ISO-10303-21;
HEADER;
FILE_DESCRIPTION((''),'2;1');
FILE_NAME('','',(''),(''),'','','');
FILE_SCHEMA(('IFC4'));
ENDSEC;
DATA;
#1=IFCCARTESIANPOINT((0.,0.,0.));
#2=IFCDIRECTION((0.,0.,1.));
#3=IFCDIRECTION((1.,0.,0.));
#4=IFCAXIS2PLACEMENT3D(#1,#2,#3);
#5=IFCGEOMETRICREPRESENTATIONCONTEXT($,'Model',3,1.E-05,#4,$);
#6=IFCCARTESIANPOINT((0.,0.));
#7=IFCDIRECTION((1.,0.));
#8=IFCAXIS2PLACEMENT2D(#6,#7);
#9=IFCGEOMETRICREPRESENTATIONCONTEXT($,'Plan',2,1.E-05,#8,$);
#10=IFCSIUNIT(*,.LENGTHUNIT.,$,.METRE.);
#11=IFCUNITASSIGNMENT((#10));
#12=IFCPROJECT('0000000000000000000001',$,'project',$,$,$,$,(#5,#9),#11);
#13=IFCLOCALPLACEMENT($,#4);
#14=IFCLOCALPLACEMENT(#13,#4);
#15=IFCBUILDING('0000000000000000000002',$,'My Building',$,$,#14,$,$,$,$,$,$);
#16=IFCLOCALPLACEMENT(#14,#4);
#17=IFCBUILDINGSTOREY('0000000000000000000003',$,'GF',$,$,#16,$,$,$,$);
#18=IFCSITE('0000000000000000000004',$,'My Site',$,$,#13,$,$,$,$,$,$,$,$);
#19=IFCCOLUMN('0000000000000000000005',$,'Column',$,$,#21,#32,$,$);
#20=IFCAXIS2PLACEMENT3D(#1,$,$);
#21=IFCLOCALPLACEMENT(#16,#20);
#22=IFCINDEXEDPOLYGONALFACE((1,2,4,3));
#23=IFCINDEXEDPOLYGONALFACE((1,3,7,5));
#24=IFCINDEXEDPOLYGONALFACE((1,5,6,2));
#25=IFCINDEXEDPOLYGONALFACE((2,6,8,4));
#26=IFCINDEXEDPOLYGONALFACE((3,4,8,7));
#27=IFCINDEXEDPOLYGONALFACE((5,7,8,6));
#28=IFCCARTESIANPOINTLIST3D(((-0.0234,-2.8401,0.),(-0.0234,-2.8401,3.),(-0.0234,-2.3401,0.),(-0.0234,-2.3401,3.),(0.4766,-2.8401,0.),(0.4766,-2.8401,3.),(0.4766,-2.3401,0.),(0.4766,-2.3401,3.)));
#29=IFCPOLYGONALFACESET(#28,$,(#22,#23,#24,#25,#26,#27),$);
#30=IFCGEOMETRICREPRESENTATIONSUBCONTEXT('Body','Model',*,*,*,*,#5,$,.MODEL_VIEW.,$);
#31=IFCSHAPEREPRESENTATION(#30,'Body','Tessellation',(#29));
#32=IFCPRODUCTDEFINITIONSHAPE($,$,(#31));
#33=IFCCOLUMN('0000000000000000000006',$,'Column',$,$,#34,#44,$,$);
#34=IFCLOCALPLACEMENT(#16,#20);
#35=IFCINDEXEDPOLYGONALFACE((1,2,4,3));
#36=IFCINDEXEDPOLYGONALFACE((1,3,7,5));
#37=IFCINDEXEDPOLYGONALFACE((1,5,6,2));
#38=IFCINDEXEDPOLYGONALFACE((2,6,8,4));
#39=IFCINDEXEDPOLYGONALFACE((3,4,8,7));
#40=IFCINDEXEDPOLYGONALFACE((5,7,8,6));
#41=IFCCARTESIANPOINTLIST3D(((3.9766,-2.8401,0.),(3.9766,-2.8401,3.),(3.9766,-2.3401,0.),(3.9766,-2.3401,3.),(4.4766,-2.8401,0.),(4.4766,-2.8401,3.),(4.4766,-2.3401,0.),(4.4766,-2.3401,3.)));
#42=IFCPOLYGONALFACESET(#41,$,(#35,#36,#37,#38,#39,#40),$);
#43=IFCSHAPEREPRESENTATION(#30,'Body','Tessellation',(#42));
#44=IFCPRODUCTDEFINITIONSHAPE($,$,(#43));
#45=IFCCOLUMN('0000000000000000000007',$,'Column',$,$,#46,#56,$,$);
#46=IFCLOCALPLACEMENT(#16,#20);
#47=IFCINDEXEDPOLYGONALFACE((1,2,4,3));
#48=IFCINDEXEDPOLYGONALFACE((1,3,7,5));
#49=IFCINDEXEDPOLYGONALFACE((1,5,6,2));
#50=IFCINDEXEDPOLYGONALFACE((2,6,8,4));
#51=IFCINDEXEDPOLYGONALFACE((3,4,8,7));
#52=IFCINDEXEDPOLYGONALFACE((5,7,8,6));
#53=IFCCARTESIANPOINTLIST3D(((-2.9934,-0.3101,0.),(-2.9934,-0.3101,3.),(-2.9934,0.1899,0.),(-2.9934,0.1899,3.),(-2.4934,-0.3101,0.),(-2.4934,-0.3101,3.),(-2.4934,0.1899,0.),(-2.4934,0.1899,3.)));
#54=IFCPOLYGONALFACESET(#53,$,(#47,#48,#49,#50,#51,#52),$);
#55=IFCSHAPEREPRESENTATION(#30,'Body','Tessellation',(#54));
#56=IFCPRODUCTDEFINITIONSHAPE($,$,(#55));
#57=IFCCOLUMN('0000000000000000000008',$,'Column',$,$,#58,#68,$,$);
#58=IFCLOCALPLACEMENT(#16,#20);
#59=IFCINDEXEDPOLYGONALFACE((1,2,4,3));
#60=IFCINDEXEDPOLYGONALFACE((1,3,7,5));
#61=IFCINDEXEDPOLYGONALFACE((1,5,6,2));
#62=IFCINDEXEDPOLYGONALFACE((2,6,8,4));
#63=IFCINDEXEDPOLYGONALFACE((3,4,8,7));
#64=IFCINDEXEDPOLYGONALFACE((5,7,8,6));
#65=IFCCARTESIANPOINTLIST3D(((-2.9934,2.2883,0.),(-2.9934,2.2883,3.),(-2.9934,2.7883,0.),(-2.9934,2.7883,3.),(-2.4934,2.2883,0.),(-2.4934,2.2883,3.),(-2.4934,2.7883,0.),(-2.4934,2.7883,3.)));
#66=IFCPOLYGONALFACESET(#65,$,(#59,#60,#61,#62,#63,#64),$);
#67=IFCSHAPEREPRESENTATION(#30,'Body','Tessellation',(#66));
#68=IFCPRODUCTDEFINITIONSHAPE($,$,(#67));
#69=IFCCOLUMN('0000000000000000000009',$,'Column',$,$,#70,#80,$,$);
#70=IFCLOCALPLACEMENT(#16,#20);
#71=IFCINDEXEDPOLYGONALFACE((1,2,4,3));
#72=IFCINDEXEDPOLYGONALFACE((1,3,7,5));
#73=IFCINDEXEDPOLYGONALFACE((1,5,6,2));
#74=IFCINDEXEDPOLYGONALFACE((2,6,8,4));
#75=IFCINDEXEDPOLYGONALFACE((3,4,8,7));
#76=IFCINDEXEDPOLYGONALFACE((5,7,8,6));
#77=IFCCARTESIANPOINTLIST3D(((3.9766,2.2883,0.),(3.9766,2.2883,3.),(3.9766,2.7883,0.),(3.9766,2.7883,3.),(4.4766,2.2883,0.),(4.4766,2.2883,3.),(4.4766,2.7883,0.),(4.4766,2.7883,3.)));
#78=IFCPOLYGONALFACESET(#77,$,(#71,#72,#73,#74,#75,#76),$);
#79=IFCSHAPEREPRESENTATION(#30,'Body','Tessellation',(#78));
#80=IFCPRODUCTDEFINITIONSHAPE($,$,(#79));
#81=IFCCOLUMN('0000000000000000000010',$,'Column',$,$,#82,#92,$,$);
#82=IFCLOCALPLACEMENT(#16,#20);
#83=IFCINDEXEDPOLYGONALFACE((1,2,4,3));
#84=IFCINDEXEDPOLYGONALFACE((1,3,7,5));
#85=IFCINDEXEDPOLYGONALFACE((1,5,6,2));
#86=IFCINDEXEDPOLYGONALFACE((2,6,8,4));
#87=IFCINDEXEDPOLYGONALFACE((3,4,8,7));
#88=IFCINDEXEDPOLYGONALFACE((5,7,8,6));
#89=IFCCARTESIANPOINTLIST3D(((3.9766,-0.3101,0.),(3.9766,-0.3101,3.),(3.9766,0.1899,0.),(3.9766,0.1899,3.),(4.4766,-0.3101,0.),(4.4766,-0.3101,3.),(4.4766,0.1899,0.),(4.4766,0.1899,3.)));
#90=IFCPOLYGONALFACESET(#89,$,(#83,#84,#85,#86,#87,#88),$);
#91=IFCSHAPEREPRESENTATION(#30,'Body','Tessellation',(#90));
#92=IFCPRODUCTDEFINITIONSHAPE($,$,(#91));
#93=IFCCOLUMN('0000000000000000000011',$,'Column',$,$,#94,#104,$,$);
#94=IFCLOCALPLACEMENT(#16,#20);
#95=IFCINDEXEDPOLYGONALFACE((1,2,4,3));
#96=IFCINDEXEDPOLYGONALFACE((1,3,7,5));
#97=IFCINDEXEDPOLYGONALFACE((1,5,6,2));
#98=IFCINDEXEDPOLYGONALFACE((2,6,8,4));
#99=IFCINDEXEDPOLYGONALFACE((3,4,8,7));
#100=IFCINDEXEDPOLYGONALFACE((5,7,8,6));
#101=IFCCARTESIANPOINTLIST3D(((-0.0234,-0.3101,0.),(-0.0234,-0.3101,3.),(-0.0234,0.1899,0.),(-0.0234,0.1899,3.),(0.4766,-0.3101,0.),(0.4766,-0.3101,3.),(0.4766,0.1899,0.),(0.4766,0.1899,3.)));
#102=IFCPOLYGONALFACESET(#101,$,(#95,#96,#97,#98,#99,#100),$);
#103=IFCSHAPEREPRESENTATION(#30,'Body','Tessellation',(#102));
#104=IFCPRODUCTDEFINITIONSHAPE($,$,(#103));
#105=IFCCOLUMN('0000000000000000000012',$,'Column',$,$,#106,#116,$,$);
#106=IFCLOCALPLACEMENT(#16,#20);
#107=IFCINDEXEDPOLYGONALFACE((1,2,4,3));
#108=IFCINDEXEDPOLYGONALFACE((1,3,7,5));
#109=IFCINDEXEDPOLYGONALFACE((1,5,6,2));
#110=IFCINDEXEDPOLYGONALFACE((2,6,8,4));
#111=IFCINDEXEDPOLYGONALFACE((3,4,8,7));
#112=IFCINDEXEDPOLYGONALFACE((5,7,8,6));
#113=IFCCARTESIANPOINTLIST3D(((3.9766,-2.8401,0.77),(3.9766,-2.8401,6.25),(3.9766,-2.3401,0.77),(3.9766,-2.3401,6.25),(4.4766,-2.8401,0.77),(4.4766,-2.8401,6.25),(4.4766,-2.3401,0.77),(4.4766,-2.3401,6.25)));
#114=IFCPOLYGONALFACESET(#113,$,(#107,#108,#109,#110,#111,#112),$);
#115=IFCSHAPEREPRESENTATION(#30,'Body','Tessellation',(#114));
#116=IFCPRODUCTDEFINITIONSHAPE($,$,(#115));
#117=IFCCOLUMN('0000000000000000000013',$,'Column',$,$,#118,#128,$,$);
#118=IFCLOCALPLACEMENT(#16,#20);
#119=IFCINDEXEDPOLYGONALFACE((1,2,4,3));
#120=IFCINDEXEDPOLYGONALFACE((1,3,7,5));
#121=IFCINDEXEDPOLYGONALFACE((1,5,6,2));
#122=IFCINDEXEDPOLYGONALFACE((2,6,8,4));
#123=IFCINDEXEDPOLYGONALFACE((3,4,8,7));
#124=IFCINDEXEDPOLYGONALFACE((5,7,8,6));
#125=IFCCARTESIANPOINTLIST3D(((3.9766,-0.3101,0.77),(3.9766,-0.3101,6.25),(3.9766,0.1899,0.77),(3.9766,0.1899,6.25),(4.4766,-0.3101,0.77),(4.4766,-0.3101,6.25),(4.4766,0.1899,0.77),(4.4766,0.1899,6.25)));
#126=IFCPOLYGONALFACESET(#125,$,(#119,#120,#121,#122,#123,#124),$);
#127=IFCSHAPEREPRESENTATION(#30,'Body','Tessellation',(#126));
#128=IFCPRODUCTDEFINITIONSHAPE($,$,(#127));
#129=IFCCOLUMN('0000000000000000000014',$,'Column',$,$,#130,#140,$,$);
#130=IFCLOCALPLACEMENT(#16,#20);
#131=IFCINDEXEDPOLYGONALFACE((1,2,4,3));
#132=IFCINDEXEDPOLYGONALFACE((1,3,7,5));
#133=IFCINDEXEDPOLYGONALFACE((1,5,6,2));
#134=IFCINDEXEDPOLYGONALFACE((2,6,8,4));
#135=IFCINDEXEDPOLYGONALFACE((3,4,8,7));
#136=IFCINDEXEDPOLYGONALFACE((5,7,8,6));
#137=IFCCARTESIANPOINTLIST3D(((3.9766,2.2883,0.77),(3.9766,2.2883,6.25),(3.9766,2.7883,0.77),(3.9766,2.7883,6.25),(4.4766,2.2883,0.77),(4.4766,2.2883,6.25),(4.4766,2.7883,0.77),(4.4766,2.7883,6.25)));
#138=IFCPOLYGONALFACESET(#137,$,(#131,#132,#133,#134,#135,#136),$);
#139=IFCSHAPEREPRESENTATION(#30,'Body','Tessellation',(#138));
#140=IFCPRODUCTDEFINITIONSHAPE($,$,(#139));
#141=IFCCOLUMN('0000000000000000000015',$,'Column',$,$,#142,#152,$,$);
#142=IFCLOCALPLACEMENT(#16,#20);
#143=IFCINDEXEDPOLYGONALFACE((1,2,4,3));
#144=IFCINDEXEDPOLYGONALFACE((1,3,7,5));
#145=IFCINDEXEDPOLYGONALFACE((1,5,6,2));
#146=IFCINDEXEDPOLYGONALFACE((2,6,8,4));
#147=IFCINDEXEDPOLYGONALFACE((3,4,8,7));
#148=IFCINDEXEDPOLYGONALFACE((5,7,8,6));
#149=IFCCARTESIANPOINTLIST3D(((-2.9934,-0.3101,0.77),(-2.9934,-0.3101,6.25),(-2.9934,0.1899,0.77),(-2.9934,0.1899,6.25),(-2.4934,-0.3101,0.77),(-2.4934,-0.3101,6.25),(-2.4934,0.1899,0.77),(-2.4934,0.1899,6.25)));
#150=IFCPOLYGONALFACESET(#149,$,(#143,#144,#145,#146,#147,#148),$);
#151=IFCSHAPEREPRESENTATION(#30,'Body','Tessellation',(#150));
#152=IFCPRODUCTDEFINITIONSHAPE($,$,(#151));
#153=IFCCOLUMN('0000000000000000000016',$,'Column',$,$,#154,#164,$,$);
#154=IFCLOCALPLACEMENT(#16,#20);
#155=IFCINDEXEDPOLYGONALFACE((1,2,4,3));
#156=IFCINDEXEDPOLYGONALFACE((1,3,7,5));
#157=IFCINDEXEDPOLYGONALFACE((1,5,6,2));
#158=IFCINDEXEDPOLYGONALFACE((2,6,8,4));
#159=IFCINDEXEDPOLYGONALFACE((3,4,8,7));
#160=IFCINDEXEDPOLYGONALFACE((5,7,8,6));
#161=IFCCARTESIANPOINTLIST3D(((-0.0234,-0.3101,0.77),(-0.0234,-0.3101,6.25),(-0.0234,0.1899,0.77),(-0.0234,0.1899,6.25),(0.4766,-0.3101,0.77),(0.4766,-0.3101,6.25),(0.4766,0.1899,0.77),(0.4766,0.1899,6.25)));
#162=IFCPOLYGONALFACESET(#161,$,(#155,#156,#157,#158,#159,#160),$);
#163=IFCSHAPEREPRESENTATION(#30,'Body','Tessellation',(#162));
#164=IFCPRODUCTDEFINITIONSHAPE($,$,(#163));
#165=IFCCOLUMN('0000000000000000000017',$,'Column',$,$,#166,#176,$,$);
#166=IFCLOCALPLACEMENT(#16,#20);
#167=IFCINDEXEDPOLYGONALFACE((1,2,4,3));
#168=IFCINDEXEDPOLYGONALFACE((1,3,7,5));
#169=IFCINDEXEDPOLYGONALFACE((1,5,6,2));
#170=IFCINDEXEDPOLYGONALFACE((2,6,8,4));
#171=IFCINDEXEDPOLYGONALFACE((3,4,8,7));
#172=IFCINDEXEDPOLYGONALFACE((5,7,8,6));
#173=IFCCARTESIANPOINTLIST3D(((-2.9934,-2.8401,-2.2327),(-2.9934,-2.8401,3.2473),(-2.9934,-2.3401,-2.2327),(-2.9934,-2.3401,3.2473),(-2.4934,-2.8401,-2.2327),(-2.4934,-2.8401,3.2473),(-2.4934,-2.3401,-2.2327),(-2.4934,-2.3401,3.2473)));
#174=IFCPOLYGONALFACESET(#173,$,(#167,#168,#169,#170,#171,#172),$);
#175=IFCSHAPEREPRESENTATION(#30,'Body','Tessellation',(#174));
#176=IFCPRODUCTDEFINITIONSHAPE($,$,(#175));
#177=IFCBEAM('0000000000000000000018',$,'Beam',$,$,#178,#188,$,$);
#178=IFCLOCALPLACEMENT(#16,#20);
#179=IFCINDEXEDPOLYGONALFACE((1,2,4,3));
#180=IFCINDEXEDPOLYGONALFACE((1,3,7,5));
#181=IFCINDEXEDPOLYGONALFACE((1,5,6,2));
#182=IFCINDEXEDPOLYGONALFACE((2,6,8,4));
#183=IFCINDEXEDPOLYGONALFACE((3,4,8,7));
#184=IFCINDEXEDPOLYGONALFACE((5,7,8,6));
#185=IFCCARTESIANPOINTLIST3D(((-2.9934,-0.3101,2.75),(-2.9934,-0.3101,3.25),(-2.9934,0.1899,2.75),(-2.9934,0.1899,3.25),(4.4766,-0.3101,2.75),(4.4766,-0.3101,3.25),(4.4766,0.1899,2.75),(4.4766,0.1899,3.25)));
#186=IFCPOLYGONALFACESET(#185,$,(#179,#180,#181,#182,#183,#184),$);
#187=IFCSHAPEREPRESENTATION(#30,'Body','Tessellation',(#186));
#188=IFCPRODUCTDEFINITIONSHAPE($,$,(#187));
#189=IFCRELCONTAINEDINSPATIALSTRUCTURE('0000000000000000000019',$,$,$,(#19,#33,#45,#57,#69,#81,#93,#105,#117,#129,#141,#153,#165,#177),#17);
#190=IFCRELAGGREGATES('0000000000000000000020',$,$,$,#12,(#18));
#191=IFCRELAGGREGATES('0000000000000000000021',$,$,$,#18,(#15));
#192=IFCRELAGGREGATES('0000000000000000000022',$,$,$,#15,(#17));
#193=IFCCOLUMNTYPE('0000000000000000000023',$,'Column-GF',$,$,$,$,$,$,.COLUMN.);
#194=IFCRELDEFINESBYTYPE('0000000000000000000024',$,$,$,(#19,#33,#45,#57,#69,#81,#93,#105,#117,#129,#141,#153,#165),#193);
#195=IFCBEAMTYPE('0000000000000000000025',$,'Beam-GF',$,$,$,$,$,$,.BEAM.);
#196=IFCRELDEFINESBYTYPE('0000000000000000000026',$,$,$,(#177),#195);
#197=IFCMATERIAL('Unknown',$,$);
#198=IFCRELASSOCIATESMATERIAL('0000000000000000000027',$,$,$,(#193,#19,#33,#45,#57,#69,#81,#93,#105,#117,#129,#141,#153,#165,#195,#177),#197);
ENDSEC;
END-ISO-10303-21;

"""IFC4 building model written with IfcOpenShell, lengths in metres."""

from ifc_helpers import new_model, si_unit, frame, origin_with_axes, origin_2d_with_axis, place, context, subcontext, project, spatial, rectangle, extrude, material, material_profile, profile_set, profile_usage, type_object, element, save


model = new_model("IFC4")

# Units and contexts
model_context = context("Model", 3, precision=1e-05, world=origin_with_axes())
plan_context = context("Plan", 2, precision=1e-05, world=origin_2d_with_axis())
body_context_1 = subcontext(model_context, "Body", "Model", "MODEL_VIEW")
ifc_project = project(units=[si_unit("LENGTHUNIT", "METRE")], contexts=[model_context, plan_context])

# Site, building, storey
site_placement = place(None, origin_with_axes())
site = spatial("IfcSite", under=ifc_project, at=site_placement, Name="My Site")
building_placement = place(site_placement, origin_with_axes())
building = spatial("IfcBuilding", under=site, at=building_placement, Name="My Building")
storey_placement = place(building_placement, origin_with_axes())
storey = spatial("IfcBuildingStorey", under=building, at=storey_placement, Name="GF")

# Columns
ifc_material = material(Name="Unknown")
ifc_material_profile_1 = material_profile(ifc_material, rectangle(XDim=0.5, YDim=0.5))
ifc_profile_set_1 = profile_set([ifc_material_profile_1])
ifc_profile_usage_1 = profile_usage(ifc_profile_set_1, cardinal=5)
column_type = type_object("IfcColumnType", Name="Column-GF", PredefinedType="COLUMN", material=ifc_profile_set_1)
column_1_placement = place(storey_placement, frame((0.2266, -2.5901, 0.0), z_axis=(0.0, 0.0, 1.0), x_axis=(1.0, 0.0, 0.0)))
element("IfcColumn", 1, at=column_1_placement, inside=storey, type_object=column_type, material=ifc_profile_usage_1, Name="Column", context=body_context_1, shape_type="SweptSolid", body=[
    extrude(rectangle(XDim=0.5, YDim=0.5), origin_with_axes(), (0.0, 0.0, 1.0), 3.0),
])
ifc_profile_usage_2 = profile_usage(ifc_profile_set_1, cardinal=5)
column_2_placement = place(storey_placement, frame((4.2266, -2.5901, 0.0), z_axis=(0.0, 0.0, 1.0), x_axis=(1.0, 0.0, 0.0)))
element("IfcColumn", 2, at=column_2_placement, inside=storey, type_object=column_type, material=ifc_profile_usage_2, Name="Column", context=body_context_1, shape_type="SweptSolid", body=[
    extrude(rectangle(XDim=0.5, YDim=0.5), origin_with_axes(), (0.0, 0.0, 1.0), 3.0),
])
ifc_profile_usage_3 = profile_usage(ifc_profile_set_1, cardinal=5)
column_3_placement = place(storey_placement, frame((-2.7434, -0.0601, 0.0), z_axis=(0.0, 0.0, 1.0), x_axis=(1.0, 0.0, 0.0)))
element("IfcColumn", 3, at=column_3_placement, inside=storey, type_object=column_type, material=ifc_profile_usage_3, Name="Column", context=body_context_1, shape_type="SweptSolid", body=[
    extrude(rectangle(XDim=0.5, YDim=0.5), origin_with_axes(), (0.0, 0.0, 1.0), 3.0),
])
ifc_profile_usage_4 = profile_usage(ifc_profile_set_1, cardinal=5)
column_4_placement = place(storey_placement, frame((-2.7434, 2.5383, 0.0), z_axis=(0.0, 0.0, 1.0), x_axis=(1.0, 0.0, 0.0)))
element("IfcColumn", 4, at=column_4_placement, inside=storey, type_object=column_type, material=ifc_profile_usage_4, Name="Column", context=body_context_1, shape_type="SweptSolid", body=[
    extrude(rectangle(XDim=0.5, YDim=0.5), origin_with_axes(), (0.0, 0.0, 1.0), 3.0),
])
ifc_profile_usage_5 = profile_usage(ifc_profile_set_1, cardinal=5)
column_5_placement = place(storey_placement, frame((4.2266, 2.5383, 0.0), z_axis=(0.0, 0.0, 1.0), x_axis=(1.0, 0.0, 0.0)))
element("IfcColumn", 5, at=column_5_placement, inside=storey, type_object=column_type, material=ifc_profile_usage_5, Name="Column", context=body_context_1, shape_type="SweptSolid", body=[
    extrude(rectangle(XDim=0.5, YDim=0.5), origin_with_axes(), (0.0, 0.0, 1.0), 3.0),
])
ifc_profile_usage_6 = profile_usage(ifc_profile_set_1, cardinal=5)
column_6_placement = place(storey_placement, frame((4.2266, -0.0601, 0.0), z_axis=(0.0, 0.0, 1.0), x_axis=(1.0, 0.0, 0.0)))
element("IfcColumn", 6, at=column_6_placement, inside=storey, type_object=column_type, material=ifc_profile_usage_6, Name="Column", context=body_context_1, shape_type="SweptSolid", body=[
    extrude(rectangle(XDim=0.5, YDim=0.5), origin_with_axes(), (0.0, 0.0, 1.0), 3.0),
])
ifc_profile_usage_7 = profile_usage(ifc_profile_set_1, cardinal=5)
column_7_placement = place(storey_placement, frame((0.2266, -0.0601, 0.0), z_axis=(0.0, 0.0, 1.0), x_axis=(1.0, 0.0, 0.0)))
element("IfcColumn", 7, at=column_7_placement, inside=storey, type_object=column_type, material=ifc_profile_usage_7, Name="Column", context=body_context_1, shape_type="SweptSolid", body=[
    extrude(rectangle(XDim=0.5, YDim=0.5), origin_with_axes(), (0.0, 0.0, 1.0), 3.0),
])
ifc_profile_usage_8 = profile_usage(ifc_profile_set_1, cardinal=5)
column_8_placement = place(storey_placement, frame((4.2266, -2.5901, 0.77), z_axis=(0.0, 0.0, 1.0), x_axis=(1.0, 0.0, 0.0)))
element("IfcColumn", 8, at=column_8_placement, inside=storey, type_object=column_type, material=ifc_profile_usage_8, Name="Column", context=body_context_1, shape_type="SweptSolid", body=[
    extrude(rectangle(XDim=0.5, YDim=0.5), origin_with_axes(), (0.0, 0.0, 1.0), 5.48),
])
ifc_profile_usage_9 = profile_usage(ifc_profile_set_1, cardinal=5)
column_9_placement = place(storey_placement, frame((4.2266, -0.0601, 0.77), z_axis=(0.0, 0.0, 1.0), x_axis=(1.0, 0.0, 0.0)))
element("IfcColumn", 9, at=column_9_placement, inside=storey, type_object=column_type, material=ifc_profile_usage_9, Name="Column", context=body_context_1, shape_type="SweptSolid", body=[
    extrude(rectangle(XDim=0.5, YDim=0.5), origin_with_axes(), (0.0, 0.0, 1.0), 5.48),
])
ifc_profile_usage_10 = profile_usage(ifc_profile_set_1, cardinal=5)
column_10_placement = place(storey_placement, frame((4.2266, 2.5383, 0.77), z_axis=(0.0, 0.0, 1.0), x_axis=(1.0, 0.0, 0.0)))
element("IfcColumn", 10, at=column_10_placement, inside=storey, type_object=column_type, material=ifc_profile_usage_10, Name="Column", context=body_context_1, shape_type="SweptSolid", body=[
    extrude(rectangle(XDim=0.5, YDim=0.5), origin_with_axes(), (0.0, 0.0, 1.0), 5.48),
])
ifc_profile_usage_11 = profile_usage(ifc_profile_set_1, cardinal=5)
column_11_placement = place(storey_placement, frame((-2.7434, -0.0601, 0.77), z_axis=(0.0, 0.0, 1.0), x_axis=(1.0, 0.0, 0.0)))
element("IfcColumn", 11, at=column_11_placement, inside=storey, type_object=column_type, material=ifc_profile_usage_11, Name="Column", context=body_context_1, shape_type="SweptSolid", body=[
    extrude(rectangle(XDim=0.5, YDim=0.5), origin_with_axes(), (0.0, 0.0, 1.0), 5.48),
])
ifc_profile_usage_12 = profile_usage(ifc_profile_set_1, cardinal=5)
column_12_placement = place(storey_placement, frame((0.2266, -0.0601, 0.77), z_axis=(0.0, 0.0, 1.0), x_axis=(1.0, 0.0, 0.0)))
element("IfcColumn", 12, at=column_12_placement, inside=storey, type_object=column_type, material=ifc_profile_usage_12, Name="Column", context=body_context_1, shape_type="SweptSolid", body=[
    extrude(rectangle(XDim=0.5, YDim=0.5), origin_with_axes(), (0.0, 0.0, 1.0), 5.48),
])
ifc_profile_usage_13 = profile_usage(ifc_profile_set_1, cardinal=5)
column_13_placement = place(storey_placement, frame((-2.7434, -2.5901, -2.2327), z_axis=(0.0, 0.0, 1.0), x_axis=(1.0, 0.0, 0.0)))
element("IfcColumn", 13, at=column_13_placement, inside=storey, type_object=column_type, material=ifc_profile_usage_13, Name="Column", context=body_context_1, shape_type="SweptSolid", body=[
    extrude(rectangle(XDim=0.5, YDim=0.5), origin_with_axes(), (0.0, 0.0, 1.0), 5.48),
])

# Beam
ifc_material_profile_2 = material_profile(ifc_material, rectangle(XDim=0.5, YDim=0.5))
ifc_profile_set_2 = profile_set([ifc_material_profile_2])
ifc_profile_usage_14 = profile_usage(ifc_profile_set_2, cardinal=5)
beam_type = type_object("IfcBeamType", Name="Beam-GF", PredefinedType="BEAM", material=ifc_profile_set_2)
beam_1_placement = place(storey_placement, frame((4.4766, -0.0601, 3.0), z_axis=(-1.0, -0.000001, 0.000001), x_axis=(0.000001, -1.0, 0.0)))
element("IfcBeam", 14, at=beam_1_placement, inside=storey, type_object=beam_type, material=ifc_profile_usage_14, Name="Beam", context=body_context_1, shape_type="SweptSolid", body=[
    extrude(rectangle(XDim=0.5, YDim=0.5), origin_with_axes(), (0.0, 0.0, 1.0), 7.47),
])

save(model, "model.ifc")
